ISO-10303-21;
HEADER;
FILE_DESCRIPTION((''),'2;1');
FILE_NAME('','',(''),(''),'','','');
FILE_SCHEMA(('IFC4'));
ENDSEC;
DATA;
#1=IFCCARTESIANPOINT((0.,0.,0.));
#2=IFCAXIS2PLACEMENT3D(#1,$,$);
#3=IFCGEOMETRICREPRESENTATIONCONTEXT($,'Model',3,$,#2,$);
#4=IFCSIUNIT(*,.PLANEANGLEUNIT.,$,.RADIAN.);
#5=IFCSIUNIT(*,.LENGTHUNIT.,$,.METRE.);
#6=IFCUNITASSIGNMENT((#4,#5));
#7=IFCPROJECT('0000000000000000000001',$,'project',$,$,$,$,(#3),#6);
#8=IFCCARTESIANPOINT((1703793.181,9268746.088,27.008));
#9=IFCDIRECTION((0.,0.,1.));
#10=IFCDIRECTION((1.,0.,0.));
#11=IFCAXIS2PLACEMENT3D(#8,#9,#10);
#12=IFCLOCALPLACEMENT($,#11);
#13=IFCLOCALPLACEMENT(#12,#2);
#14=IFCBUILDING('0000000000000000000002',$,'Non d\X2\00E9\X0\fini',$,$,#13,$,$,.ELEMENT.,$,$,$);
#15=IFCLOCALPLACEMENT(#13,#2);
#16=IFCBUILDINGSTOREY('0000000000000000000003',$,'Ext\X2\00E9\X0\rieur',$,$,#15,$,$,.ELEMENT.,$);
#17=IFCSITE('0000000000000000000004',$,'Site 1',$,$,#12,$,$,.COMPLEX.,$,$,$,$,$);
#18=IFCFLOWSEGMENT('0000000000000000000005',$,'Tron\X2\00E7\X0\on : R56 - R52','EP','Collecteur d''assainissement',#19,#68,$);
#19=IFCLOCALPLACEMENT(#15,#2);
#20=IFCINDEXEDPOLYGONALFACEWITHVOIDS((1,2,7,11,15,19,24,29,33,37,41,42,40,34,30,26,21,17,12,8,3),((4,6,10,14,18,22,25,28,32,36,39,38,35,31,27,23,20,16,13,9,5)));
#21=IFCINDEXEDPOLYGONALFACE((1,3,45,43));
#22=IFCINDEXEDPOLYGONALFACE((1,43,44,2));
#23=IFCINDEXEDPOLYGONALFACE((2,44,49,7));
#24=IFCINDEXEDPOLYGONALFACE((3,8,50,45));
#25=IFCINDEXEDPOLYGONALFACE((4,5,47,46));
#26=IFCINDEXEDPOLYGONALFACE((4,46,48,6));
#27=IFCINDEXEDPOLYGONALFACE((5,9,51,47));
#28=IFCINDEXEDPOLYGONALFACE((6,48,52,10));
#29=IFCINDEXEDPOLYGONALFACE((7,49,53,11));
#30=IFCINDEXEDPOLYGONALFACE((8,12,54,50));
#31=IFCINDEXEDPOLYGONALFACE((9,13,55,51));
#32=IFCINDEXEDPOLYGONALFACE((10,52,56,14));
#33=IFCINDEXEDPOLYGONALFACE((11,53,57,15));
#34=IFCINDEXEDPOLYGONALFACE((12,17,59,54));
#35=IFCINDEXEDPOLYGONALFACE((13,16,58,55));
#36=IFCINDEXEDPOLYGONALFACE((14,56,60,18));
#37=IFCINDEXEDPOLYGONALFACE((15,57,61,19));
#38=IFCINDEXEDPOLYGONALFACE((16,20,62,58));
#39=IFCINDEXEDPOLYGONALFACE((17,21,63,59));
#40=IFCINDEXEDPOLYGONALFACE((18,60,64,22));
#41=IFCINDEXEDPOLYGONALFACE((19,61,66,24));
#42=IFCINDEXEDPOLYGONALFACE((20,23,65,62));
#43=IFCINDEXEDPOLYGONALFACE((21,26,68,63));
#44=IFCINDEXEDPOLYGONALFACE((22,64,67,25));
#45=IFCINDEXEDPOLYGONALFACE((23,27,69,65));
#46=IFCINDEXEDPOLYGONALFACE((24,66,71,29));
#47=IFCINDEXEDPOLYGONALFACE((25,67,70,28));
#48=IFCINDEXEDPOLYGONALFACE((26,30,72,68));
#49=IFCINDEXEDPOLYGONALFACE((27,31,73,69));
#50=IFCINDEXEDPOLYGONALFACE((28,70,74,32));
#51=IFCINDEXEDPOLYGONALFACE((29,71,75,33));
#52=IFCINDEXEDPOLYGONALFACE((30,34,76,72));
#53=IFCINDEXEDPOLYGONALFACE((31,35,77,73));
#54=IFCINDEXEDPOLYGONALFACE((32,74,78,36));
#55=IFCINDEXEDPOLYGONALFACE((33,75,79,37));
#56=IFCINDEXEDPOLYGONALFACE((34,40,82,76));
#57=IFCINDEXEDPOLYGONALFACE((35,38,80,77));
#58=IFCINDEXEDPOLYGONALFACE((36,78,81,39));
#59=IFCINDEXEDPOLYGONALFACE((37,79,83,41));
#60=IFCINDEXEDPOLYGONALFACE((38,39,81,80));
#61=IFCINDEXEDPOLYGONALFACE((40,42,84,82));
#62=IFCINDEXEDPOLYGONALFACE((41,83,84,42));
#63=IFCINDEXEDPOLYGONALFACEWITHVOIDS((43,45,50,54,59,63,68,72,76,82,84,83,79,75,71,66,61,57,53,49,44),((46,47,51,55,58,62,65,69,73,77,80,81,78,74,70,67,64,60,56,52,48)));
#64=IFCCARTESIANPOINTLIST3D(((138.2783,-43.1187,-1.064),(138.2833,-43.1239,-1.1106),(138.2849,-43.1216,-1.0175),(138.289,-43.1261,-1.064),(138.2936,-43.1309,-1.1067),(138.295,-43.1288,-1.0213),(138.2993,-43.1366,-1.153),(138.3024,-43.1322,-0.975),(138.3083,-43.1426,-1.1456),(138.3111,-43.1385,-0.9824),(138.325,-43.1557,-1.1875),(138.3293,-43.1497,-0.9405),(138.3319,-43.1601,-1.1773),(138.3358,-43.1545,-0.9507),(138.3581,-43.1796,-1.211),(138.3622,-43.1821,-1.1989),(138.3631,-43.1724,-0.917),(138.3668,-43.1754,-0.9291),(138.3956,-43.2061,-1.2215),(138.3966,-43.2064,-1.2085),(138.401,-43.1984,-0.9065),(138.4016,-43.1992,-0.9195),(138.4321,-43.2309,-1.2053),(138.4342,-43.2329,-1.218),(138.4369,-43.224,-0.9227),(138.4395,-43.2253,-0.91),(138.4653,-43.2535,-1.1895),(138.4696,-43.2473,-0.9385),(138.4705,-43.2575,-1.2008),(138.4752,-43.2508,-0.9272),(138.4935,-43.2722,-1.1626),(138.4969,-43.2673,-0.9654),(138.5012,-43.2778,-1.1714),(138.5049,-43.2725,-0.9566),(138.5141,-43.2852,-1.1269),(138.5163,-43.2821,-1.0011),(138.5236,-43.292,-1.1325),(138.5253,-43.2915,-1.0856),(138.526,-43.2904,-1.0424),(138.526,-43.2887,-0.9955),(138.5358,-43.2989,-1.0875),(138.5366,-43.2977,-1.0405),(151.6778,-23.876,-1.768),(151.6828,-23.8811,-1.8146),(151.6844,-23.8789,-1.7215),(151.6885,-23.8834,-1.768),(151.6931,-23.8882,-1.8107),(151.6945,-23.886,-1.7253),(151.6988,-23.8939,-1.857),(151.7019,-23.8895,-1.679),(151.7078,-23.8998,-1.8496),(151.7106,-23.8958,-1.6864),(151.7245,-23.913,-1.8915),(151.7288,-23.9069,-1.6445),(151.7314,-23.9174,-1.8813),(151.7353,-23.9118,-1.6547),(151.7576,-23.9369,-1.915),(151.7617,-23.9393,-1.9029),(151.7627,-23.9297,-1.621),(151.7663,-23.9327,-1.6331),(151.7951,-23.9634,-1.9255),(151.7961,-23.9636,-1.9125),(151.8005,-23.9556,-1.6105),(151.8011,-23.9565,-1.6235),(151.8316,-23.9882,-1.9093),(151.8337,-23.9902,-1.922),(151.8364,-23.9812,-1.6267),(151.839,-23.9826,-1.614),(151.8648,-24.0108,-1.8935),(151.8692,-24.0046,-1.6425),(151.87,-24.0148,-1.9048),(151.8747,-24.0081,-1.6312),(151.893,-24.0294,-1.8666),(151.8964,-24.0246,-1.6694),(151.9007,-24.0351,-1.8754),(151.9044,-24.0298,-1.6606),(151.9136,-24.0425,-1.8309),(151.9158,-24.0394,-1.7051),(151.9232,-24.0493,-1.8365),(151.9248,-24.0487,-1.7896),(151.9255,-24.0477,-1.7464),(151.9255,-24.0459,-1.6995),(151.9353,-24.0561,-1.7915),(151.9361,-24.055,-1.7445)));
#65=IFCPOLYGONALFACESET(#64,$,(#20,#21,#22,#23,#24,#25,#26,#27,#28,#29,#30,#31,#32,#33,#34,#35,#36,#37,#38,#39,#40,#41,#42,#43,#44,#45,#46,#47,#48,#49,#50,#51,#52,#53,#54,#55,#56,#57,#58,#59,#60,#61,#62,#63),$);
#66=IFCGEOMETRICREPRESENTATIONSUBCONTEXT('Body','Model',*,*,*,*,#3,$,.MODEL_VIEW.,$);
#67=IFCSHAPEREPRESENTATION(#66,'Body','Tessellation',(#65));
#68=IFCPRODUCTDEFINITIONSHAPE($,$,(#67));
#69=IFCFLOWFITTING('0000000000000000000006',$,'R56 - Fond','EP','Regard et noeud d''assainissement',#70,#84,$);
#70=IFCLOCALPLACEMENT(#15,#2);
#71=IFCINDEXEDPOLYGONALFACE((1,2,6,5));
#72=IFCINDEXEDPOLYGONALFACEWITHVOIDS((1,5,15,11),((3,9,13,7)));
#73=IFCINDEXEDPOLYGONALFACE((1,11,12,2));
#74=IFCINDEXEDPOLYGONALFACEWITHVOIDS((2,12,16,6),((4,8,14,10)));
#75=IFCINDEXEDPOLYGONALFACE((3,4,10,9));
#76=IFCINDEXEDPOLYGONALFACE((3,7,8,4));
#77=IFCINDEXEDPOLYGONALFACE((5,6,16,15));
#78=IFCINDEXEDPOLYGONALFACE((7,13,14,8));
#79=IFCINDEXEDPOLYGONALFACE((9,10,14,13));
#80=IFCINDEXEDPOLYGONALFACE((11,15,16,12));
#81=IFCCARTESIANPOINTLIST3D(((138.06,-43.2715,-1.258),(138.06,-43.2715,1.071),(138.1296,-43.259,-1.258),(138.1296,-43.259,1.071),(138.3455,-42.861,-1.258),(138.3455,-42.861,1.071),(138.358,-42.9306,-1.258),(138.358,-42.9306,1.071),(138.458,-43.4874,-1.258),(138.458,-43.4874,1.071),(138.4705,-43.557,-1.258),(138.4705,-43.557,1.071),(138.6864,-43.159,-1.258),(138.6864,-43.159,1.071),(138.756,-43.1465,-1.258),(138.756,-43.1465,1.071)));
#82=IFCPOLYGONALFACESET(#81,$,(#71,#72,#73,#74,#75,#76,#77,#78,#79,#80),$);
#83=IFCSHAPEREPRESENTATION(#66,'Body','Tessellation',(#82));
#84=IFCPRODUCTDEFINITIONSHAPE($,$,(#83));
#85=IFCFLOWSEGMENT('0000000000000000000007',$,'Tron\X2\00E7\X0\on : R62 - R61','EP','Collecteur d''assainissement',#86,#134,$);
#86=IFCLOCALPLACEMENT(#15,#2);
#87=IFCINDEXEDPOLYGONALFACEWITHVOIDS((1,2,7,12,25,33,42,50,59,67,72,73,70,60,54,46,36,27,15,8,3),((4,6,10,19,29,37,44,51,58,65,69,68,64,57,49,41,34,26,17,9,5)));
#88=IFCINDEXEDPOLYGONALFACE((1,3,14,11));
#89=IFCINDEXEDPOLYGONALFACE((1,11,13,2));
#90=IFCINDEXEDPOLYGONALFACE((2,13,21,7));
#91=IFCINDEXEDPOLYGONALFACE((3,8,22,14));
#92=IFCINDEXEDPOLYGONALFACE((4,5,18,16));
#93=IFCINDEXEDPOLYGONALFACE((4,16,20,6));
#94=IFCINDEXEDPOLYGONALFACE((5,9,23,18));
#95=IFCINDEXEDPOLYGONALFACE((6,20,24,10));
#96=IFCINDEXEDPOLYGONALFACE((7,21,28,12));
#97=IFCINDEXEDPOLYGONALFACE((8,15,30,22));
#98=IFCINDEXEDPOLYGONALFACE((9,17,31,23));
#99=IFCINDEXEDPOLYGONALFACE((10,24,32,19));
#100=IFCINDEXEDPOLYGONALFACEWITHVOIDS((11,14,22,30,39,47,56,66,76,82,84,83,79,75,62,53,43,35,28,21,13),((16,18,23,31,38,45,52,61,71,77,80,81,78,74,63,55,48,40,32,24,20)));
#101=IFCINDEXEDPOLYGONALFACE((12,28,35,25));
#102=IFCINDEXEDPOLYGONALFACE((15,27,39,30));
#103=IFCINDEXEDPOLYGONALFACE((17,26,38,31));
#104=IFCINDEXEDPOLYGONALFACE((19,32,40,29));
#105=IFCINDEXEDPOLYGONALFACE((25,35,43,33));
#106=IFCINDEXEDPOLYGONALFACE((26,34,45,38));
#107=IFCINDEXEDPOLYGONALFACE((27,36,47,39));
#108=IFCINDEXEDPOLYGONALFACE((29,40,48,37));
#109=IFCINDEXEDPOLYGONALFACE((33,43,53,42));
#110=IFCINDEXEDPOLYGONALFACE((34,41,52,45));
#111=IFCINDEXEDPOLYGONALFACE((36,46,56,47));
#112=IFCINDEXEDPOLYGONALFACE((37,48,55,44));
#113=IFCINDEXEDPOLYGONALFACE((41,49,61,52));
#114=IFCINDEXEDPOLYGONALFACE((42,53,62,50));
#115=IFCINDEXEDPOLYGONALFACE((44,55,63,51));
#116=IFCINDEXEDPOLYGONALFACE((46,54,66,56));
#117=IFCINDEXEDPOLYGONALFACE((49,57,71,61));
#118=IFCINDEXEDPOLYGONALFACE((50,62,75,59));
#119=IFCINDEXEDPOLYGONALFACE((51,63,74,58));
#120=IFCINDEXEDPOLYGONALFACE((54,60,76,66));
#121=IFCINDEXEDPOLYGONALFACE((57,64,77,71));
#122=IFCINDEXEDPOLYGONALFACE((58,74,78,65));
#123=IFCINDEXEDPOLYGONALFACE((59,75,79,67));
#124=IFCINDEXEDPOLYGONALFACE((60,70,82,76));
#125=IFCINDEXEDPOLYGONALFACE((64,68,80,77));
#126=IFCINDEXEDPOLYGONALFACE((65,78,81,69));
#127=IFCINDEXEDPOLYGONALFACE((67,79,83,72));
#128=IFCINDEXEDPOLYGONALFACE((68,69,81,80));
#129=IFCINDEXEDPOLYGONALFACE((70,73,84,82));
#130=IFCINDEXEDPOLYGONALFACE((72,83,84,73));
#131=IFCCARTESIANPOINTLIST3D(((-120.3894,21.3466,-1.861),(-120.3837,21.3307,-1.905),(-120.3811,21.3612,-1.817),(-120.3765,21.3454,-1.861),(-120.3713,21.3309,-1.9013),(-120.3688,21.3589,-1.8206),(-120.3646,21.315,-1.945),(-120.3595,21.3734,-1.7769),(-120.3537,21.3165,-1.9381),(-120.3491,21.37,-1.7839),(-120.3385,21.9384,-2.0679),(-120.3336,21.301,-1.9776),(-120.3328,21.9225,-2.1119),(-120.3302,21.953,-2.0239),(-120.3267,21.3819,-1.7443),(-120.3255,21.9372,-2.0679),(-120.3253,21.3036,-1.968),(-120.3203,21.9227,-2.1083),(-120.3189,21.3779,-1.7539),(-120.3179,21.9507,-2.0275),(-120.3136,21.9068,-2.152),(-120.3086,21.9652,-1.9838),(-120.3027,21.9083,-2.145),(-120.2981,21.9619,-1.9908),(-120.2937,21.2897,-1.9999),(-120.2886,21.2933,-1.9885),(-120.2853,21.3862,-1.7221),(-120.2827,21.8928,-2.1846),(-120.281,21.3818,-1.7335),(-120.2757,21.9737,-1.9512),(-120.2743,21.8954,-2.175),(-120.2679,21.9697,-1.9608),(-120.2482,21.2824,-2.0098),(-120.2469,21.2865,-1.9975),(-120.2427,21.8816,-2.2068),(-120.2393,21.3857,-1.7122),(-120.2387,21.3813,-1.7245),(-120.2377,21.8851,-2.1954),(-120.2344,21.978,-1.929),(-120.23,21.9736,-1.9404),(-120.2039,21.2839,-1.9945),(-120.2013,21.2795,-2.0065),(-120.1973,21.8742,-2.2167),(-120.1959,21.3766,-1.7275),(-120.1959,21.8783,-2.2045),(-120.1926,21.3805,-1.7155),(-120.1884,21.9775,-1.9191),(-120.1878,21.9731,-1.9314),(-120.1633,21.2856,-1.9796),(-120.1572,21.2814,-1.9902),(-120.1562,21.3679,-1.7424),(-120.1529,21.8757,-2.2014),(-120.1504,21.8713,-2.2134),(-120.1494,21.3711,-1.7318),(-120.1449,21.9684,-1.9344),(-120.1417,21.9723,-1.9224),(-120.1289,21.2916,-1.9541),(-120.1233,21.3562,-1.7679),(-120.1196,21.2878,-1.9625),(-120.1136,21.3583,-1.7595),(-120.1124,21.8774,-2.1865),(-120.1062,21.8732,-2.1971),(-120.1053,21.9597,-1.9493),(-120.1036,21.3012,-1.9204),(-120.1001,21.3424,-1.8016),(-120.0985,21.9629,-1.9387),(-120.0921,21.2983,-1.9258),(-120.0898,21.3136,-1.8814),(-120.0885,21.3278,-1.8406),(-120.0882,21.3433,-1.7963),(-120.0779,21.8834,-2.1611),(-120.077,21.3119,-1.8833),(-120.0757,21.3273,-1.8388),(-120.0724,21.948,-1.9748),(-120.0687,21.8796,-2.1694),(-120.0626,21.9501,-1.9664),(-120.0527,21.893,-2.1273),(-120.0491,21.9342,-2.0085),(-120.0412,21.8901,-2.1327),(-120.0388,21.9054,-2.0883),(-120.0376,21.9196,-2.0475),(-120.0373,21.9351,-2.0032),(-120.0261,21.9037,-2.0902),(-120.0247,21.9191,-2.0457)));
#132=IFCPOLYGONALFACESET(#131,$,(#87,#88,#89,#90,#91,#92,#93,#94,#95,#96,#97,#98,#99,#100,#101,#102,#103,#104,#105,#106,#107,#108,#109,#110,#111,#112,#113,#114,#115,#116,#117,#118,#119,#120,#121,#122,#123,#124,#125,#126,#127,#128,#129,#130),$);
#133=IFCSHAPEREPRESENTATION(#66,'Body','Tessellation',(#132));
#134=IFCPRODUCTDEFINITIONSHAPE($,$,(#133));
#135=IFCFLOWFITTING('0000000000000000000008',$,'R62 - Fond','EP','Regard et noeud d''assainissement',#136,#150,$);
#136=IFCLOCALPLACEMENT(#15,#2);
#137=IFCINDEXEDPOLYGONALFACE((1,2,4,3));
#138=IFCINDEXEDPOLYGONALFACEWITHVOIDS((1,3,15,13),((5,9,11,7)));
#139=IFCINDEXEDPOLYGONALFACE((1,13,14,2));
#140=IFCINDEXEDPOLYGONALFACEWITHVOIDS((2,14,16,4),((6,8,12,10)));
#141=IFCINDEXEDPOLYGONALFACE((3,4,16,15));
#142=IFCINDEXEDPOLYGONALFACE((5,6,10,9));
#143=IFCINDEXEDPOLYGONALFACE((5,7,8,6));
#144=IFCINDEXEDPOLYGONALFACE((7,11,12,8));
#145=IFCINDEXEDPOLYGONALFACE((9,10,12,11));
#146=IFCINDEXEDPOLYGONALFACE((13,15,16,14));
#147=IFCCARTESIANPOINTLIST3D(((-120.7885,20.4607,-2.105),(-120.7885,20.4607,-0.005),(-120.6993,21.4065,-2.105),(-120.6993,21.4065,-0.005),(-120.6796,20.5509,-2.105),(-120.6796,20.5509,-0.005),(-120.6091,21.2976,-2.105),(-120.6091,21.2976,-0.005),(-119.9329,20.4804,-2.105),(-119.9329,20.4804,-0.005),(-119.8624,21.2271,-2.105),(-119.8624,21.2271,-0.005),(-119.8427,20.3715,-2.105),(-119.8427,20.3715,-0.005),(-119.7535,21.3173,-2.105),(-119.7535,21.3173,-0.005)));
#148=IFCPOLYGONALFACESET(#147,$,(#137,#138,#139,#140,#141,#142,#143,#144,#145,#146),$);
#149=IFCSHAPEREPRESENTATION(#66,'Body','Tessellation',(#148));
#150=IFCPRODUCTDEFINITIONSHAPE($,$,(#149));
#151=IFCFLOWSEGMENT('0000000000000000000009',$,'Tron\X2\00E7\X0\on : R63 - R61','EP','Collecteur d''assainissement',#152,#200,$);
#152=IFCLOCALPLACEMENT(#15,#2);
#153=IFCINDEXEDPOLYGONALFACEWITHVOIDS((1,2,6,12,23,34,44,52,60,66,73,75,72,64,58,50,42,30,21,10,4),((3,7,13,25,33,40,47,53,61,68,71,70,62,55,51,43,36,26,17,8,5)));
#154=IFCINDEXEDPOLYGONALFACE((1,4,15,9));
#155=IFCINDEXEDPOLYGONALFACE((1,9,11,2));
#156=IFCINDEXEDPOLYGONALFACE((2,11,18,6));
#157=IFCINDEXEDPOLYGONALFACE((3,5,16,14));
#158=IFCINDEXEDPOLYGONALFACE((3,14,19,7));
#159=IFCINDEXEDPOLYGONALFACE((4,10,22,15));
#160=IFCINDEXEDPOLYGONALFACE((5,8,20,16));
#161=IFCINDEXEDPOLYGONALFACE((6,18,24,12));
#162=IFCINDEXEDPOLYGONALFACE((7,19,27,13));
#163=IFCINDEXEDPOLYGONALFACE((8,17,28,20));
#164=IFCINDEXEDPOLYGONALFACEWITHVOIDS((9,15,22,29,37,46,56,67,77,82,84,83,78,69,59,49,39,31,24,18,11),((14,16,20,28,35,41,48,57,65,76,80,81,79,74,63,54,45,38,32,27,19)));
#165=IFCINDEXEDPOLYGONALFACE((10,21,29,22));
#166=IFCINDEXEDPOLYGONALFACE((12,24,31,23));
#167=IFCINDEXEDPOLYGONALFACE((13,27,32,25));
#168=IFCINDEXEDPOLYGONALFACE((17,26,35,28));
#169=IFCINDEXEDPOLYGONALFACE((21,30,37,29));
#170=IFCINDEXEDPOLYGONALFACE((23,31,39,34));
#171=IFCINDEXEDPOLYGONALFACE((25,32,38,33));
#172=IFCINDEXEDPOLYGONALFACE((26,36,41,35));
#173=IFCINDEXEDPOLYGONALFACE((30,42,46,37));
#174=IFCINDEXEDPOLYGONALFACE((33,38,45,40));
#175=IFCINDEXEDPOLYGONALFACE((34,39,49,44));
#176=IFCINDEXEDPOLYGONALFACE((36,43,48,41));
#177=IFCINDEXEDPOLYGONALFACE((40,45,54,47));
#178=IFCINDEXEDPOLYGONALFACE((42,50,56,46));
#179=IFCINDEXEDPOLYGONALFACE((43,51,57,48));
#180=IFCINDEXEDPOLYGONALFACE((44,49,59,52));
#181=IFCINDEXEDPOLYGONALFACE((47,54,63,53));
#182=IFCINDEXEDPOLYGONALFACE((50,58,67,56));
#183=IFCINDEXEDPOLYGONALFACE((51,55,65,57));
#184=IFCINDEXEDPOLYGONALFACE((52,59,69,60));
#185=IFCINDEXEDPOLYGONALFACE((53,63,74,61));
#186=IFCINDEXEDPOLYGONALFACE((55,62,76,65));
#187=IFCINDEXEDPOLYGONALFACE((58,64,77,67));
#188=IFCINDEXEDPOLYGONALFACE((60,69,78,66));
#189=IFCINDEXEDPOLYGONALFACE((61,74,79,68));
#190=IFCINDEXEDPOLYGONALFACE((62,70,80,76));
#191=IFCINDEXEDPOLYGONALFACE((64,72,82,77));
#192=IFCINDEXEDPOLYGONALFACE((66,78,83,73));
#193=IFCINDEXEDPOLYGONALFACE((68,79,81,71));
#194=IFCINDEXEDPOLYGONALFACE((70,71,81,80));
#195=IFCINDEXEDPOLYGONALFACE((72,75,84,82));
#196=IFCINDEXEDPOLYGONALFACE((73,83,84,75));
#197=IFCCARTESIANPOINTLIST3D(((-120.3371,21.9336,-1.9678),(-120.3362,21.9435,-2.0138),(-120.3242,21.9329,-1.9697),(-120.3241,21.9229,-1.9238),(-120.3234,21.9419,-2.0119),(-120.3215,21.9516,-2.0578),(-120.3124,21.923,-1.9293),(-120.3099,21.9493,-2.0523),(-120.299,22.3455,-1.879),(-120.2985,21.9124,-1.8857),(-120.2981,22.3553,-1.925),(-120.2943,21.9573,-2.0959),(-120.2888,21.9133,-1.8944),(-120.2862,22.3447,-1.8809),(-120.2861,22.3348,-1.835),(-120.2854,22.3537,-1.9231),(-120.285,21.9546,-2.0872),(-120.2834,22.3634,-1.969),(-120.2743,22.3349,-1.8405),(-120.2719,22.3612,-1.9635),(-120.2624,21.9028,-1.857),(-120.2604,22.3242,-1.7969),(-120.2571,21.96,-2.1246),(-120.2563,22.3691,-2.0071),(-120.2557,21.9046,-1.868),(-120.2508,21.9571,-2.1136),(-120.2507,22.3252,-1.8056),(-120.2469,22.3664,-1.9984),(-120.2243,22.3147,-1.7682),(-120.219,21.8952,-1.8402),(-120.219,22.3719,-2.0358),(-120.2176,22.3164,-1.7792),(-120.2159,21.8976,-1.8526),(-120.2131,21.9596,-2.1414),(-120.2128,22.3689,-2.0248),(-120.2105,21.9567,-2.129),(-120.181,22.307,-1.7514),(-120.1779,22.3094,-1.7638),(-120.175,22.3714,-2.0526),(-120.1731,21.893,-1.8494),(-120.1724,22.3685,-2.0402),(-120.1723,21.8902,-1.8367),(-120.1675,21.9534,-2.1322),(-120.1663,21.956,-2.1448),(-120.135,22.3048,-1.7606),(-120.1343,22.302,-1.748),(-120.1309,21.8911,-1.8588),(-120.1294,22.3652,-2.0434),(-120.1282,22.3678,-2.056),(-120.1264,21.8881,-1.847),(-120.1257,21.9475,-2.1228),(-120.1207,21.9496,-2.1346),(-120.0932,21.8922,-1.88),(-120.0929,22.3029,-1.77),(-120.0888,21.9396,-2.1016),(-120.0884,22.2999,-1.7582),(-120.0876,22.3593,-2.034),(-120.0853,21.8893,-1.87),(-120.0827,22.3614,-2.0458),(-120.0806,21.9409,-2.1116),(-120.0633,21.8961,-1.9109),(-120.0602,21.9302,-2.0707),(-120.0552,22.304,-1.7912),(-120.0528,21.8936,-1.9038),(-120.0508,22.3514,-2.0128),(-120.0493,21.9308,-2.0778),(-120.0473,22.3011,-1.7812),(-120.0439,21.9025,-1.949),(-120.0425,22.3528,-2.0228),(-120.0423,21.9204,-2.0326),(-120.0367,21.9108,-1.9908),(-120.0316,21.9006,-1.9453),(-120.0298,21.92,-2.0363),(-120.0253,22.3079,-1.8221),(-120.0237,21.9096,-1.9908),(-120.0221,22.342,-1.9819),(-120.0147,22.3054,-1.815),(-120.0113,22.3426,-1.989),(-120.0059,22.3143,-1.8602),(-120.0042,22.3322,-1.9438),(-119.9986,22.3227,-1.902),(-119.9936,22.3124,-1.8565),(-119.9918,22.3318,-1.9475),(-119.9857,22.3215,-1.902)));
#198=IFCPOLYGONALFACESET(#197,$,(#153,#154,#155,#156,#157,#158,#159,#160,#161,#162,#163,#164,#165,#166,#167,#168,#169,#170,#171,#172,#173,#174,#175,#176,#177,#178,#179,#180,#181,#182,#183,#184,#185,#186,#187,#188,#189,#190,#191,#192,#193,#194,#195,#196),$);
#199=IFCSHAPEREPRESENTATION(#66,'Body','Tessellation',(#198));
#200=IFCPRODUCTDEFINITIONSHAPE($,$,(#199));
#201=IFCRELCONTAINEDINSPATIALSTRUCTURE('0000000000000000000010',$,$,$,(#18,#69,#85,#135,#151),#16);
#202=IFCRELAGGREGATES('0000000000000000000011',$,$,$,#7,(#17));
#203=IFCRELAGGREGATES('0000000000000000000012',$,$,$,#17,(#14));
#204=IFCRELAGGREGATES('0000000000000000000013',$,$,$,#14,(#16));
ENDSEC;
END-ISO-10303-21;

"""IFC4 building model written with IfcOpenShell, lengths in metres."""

from ifc_helpers import new_model, si_unit, frame, origin, origin_2d, place, context, subcontext, project, spatial, hollow_rectangle, hollow_circle, extrude, element, save


model = new_model("IFC4")

# Units and contexts
model_context = context("Model", 3, world=origin())
body_context = subcontext(model_context, "Body", "Model", "MODEL_VIEW")
ifc_project = project(units=[si_unit("PLANEANGLEUNIT", "RADIAN"), si_unit("LENGTHUNIT", "METRE")], contexts=[model_context])

# Site, building, storey
site_placement = place(None, frame((1703793.181, 9268746.088, 27.008), z_axis=(0.0, 0.0, 1.0), x_axis=(1.0, 0.0, 0.0)))
site = spatial("IfcSite", under=ifc_project, at=site_placement, Name="Site 1", CompositionType="COMPLEX")
building_placement = place(site_placement, origin())
building = spatial("IfcBuilding", under=site, at=building_placement, Name="Non défini", CompositionType="ELEMENT")
storey_placement = place(building_placement, origin())
storey = spatial("IfcBuildingStorey", under=building, at=storey_placement, Name="Extérieur", CompositionType="ELEMENT")

# Flow segment
flow_segment_1_placement = place(storey_placement, origin())
element("IfcFlowSegment", 1, at=flow_segment_1_placement, inside=storey, Name="Tronçon : R56 - R52", Description="EP", ObjectType="Collecteur d'assainissement", context=body_context, shape_type="SweptSolid", body=[
    extrude(hollow_circle(Radius=0.158, WallThickness=0.013, at=origin_2d()), frame((138.408, -43.209, -1.064), z_axis=(0.571, 0.82, -0.03), x_axis=(-0.821, 0.571, 0.0)), (0.0, 0.0, 1.0), 23.459),
])

# Flow fitting
flow_fitting_1_placement = place(storey_placement, origin())
element("IfcFlowFitting", 2, at=flow_fitting_1_placement, inside=storey, Name="R56 - Fond", Description="EP", ObjectType="Regard et noeud d'assainissement", context=body_context, shape_type="SweptSolid", body=[
    extrude(hollow_rectangle(XDim=0.5, YDim=0.5, WallThickness=0.05, at=origin_2d()), frame((138.408, -43.209, -1.258), z_axis=(0.0, 0.0, 1.0), x_axis=(0.571, 0.821, 0.0)), (0.0, 0.0, 1.0), 2.329),
])

# Flow segment
flow_segment_2_placement = place(storey_placement, origin())
element("IfcFlowSegment", 3, at=flow_segment_2_placement, inside=storey, Name="Tronçon : R62 - R61", Description="EP", ObjectType="Collecteur d'assainissement", context=body_context, shape_type="SweptSolid", body=[
    extrude(hollow_circle(Radius=0.158, WallThickness=0.013, at=origin_2d()), frame((-120.232, 21.333, -1.861), z_axis=(0.081, 0.941, -0.329), x_axis=(-0.996, 0.086, 0.0)), (0.0, 0.0, 1.0), 0.629),
])

# Flow fitting
flow_fitting_2_placement = place(storey_placement, origin())
element("IfcFlowFitting", 4, at=flow_fitting_2_placement, inside=storey, Name="R62 - Fond", Description="EP", ObjectType="Regard et noeud d'assainissement", context=body_context, shape_type="SweptSolid", body=[
    extrude(hollow_rectangle(XDim=0.95, YDim=0.95, WallThickness=0.1, at=origin_2d()), frame((-120.271, 20.889, -2.105), z_axis=(0.0, 0.0, 1.0), x_axis=(0.094, 0.996, 0.0)), (0.0, 0.0, 1.0), 2.1),
])

# Flow segment
flow_segment_3_placement = place(storey_placement, origin())
element("IfcFlowSegment", 5, at=flow_segment_3_placement, inside=storey, Name="Tronçon : R63 - R61", Description="EP", ObjectType="Collecteur d'assainissement", context=body_context, shape_type="SweptSolid", body=[
    extrude(hollow_circle(Radius=0.158, WallThickness=0.013, at=origin_2d()), frame((-120.143, 22.336, -1.902), z_axis=(-0.09, -0.974, -0.21), x_axis=(0.996, -0.092, 0.0)), (0.0, 0.0, 1.0), 0.423),
])

save(model, "model.ifc")
